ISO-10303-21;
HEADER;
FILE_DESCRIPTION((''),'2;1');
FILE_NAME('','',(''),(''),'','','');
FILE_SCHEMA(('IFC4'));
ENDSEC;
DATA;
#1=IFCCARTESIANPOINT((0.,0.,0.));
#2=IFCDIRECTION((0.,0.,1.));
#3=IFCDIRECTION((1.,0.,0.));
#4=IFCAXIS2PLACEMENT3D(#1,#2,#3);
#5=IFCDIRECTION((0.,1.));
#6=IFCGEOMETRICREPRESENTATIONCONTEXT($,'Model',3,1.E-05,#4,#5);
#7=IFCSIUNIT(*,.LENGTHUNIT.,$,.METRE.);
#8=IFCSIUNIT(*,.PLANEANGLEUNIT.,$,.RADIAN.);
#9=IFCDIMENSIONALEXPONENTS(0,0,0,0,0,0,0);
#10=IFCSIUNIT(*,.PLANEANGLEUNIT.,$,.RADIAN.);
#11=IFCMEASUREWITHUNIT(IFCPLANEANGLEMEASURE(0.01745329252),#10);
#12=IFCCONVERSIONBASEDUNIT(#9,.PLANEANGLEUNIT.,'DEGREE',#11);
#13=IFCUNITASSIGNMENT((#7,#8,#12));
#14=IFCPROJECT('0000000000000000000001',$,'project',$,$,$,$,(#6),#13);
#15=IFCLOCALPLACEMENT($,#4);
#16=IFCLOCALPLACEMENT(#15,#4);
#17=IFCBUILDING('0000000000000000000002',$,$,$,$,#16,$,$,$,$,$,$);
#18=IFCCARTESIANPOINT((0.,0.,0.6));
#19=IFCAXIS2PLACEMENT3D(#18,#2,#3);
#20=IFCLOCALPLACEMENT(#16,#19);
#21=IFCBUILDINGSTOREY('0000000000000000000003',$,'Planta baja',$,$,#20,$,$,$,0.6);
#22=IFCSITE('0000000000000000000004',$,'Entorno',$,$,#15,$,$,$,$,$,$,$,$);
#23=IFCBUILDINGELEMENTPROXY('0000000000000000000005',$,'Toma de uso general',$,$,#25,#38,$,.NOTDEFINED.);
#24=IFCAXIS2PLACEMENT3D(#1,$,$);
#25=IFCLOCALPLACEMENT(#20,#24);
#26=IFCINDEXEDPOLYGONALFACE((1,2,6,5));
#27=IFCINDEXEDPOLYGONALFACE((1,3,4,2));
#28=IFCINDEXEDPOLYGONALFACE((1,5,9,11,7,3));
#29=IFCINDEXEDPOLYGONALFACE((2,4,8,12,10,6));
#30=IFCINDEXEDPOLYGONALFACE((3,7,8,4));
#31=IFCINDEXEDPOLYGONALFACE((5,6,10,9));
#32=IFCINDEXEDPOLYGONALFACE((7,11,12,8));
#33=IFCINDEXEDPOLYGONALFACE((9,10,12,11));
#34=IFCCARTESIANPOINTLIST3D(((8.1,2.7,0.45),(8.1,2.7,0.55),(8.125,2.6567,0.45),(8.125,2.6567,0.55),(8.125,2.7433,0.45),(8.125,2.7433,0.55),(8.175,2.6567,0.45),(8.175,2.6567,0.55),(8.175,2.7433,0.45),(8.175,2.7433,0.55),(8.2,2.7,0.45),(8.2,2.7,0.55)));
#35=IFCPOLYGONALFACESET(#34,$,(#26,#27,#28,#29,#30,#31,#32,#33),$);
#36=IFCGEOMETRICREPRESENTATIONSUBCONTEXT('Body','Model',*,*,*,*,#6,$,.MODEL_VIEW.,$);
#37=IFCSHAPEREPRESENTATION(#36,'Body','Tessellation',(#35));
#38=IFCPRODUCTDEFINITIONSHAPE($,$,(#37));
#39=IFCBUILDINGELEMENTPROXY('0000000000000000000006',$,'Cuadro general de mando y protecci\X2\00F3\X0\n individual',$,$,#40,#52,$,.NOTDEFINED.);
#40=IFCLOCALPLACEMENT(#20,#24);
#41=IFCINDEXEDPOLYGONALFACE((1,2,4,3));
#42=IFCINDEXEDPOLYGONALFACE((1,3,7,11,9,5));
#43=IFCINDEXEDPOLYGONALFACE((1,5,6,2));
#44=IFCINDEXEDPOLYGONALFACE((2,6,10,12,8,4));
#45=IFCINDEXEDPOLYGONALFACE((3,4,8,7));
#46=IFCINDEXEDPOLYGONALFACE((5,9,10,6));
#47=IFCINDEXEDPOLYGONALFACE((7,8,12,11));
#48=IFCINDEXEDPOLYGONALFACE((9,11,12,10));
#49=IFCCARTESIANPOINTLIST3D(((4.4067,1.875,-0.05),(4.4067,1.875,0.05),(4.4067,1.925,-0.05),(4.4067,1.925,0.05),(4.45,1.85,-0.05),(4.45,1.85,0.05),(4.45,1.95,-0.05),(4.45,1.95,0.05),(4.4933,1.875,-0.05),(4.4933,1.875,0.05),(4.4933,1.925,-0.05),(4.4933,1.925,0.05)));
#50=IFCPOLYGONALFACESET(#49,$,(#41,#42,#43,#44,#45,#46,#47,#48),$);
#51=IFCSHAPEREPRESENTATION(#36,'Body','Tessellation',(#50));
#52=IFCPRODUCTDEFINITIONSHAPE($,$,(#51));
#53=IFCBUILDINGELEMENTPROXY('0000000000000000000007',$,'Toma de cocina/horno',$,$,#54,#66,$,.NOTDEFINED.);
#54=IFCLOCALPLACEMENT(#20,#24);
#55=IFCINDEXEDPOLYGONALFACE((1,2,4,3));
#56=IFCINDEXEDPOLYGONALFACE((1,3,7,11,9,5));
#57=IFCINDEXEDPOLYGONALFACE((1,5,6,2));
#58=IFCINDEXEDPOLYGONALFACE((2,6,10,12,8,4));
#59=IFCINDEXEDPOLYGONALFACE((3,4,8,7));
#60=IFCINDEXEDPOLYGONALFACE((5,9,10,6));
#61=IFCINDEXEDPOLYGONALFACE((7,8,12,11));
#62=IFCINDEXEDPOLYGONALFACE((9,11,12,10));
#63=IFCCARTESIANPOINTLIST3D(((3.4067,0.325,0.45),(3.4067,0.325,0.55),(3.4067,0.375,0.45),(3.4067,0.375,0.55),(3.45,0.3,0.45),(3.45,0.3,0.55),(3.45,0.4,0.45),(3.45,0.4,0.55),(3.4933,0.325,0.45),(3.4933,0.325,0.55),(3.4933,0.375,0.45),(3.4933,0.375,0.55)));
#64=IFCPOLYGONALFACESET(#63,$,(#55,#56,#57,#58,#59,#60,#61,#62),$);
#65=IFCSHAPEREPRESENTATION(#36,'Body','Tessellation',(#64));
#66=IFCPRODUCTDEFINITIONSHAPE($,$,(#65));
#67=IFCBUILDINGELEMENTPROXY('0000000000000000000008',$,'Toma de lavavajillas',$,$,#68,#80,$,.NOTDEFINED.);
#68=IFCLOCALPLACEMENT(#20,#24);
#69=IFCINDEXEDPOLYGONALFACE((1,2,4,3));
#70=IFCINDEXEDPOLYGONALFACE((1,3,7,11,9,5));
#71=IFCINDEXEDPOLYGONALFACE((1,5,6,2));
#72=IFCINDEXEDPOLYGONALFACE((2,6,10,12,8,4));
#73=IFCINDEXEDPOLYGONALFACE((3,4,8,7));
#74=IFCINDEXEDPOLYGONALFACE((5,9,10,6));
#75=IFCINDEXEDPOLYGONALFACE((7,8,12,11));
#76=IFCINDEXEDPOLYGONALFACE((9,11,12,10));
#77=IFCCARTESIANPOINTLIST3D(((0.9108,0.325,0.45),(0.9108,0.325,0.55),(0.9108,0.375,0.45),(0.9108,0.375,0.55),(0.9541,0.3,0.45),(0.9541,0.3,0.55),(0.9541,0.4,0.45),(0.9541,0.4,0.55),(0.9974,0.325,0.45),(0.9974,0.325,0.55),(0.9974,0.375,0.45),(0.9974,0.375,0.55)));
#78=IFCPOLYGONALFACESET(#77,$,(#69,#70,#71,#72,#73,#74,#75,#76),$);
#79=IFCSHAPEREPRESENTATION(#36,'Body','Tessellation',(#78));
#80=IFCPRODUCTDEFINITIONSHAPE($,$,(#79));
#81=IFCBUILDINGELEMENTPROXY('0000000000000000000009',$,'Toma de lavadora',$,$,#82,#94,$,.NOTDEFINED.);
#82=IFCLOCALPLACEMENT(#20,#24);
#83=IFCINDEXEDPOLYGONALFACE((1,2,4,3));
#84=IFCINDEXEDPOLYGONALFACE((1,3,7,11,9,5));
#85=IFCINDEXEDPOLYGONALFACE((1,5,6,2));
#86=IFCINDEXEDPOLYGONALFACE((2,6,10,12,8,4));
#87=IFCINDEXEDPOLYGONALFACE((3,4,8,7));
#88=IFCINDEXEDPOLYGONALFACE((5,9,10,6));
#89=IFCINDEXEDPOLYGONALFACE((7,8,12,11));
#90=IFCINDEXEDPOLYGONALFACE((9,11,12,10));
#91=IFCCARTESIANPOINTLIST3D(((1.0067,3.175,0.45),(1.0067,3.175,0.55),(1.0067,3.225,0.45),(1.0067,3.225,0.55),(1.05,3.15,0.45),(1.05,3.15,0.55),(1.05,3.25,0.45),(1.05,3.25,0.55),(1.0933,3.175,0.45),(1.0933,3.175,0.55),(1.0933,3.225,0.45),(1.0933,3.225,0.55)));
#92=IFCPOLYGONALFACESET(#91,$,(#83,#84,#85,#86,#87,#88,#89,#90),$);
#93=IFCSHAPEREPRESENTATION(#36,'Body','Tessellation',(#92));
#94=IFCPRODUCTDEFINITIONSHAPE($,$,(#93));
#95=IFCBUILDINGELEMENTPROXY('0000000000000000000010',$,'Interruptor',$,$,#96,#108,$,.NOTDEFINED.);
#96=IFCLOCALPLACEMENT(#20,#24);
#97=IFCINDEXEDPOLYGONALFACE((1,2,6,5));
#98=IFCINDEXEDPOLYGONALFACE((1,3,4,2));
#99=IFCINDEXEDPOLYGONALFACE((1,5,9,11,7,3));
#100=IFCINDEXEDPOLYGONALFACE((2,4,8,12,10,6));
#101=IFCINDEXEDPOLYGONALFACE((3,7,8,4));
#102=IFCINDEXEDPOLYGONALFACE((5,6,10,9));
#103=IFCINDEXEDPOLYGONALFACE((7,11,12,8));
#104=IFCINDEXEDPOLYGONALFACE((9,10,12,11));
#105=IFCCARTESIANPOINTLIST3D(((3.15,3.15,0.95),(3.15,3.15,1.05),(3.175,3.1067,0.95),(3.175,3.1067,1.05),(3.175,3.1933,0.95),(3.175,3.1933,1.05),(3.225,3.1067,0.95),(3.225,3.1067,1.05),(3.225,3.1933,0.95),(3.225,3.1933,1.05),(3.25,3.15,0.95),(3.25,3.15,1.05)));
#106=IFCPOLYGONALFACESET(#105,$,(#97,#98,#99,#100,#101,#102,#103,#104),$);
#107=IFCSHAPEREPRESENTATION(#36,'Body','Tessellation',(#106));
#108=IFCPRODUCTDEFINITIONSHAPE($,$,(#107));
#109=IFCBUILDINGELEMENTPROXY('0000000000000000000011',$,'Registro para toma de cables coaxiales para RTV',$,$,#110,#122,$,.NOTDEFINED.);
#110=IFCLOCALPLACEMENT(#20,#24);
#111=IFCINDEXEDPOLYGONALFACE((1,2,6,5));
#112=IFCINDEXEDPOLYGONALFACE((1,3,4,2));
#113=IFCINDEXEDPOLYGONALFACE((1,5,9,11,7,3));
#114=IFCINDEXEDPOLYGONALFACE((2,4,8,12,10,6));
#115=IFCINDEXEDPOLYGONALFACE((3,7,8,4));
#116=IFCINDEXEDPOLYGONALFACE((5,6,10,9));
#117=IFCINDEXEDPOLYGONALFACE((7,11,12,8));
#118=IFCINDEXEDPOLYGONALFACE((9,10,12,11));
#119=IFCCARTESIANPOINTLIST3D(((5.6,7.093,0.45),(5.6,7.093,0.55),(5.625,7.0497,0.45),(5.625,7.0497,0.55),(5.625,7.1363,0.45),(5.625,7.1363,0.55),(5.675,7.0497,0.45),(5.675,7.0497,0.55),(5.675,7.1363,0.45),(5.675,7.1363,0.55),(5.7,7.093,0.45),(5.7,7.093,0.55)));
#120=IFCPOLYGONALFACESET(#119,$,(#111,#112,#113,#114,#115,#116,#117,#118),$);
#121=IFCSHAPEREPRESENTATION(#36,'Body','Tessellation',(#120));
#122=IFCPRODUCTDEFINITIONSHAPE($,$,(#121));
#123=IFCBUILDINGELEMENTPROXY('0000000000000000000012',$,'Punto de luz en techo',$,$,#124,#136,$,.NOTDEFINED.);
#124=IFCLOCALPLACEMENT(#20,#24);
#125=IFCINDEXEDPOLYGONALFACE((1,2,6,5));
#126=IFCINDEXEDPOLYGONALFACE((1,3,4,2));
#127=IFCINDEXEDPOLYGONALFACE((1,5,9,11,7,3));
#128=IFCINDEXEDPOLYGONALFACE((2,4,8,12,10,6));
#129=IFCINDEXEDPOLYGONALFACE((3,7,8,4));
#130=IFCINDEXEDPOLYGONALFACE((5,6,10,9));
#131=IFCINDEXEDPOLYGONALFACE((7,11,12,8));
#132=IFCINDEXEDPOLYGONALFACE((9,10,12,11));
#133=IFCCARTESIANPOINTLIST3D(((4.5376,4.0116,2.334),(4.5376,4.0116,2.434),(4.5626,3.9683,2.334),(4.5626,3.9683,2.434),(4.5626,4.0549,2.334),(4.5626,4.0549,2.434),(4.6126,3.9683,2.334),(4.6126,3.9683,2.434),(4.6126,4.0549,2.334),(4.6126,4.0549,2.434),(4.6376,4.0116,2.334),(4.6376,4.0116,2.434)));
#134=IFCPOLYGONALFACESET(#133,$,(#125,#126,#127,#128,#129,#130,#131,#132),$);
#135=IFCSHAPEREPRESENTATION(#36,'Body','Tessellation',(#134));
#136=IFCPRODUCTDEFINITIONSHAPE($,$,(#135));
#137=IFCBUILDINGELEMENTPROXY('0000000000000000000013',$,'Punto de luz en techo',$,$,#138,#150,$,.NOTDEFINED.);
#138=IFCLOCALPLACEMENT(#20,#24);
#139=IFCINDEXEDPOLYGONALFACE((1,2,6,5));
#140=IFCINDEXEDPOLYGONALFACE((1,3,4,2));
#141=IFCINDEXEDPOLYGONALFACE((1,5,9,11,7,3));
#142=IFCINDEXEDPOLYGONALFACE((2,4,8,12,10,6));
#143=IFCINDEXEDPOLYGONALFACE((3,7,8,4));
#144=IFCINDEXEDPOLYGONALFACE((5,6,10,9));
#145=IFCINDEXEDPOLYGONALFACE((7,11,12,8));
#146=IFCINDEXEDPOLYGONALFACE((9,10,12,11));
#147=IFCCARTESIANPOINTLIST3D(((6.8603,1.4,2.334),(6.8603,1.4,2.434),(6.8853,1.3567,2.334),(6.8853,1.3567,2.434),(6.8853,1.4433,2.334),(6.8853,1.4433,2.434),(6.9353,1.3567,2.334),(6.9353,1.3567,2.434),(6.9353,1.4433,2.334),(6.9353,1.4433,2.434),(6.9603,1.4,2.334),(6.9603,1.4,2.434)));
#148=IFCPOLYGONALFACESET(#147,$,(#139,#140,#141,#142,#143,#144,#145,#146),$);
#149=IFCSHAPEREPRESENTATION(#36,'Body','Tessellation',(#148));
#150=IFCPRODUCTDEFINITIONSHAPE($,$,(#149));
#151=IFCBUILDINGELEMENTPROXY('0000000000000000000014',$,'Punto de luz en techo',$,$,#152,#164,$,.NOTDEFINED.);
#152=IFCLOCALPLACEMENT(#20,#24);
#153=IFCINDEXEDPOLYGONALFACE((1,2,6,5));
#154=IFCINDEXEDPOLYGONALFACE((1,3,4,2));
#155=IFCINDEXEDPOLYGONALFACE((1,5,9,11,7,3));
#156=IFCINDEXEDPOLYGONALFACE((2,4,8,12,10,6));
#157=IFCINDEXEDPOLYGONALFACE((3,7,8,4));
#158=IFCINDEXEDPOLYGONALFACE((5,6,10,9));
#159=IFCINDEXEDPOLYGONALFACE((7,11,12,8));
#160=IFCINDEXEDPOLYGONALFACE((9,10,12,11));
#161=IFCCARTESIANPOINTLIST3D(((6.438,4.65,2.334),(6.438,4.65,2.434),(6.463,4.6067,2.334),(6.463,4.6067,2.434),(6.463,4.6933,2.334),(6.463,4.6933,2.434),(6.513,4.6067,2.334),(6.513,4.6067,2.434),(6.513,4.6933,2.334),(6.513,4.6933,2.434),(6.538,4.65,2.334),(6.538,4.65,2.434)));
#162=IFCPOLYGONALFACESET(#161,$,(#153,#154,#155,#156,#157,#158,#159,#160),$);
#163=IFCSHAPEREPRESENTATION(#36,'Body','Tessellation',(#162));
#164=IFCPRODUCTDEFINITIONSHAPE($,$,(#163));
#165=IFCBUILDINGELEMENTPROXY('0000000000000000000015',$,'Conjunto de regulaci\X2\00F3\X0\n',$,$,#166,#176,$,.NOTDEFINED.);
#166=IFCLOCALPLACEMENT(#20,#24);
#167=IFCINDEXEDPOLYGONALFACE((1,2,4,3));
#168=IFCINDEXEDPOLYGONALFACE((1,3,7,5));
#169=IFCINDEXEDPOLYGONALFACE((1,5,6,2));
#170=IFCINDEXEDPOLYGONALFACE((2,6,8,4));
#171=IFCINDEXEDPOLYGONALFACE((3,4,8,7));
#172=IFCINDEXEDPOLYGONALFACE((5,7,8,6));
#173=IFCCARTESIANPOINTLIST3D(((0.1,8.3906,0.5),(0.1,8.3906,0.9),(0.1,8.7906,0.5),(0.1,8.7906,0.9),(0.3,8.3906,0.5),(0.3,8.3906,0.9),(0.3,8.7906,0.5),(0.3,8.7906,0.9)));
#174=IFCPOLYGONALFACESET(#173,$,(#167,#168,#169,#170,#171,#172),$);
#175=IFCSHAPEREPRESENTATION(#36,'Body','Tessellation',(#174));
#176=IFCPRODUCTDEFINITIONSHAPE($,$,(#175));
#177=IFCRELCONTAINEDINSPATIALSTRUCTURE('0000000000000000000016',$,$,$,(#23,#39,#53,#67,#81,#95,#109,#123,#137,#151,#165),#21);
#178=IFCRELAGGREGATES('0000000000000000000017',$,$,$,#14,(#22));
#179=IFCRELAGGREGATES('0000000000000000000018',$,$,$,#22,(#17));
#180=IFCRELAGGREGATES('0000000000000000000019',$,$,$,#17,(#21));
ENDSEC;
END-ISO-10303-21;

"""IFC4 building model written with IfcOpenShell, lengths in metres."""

from ifc_helpers import new_model, entity, si_unit, converted_unit, direction, frame, origin_with_axes, place, context, subcontext, project, spatial, polyline, outline, extrude, source, transform, mapped, element, save


model = new_model("IFC4")

# Units and contexts
model_context = context("Model", 3, precision=1e-05, world=origin_with_axes(), true_north=direction((0.0, 1.0)))
body_context = subcontext(model_context, "Body", "Model", "MODEL_VIEW")
ifc_project = project(units=[si_unit("LENGTHUNIT", "METRE"), si_unit("PLANEANGLEUNIT", "RADIAN"), converted_unit("PLANEANGLEUNIT", "DEGREE", entity("IfcPlaneAngleMeasure", 0.01745329252), si_unit("PLANEANGLEUNIT", "RADIAN"), dimensions=[0, 0, 0, 0, 0, 0, 0])], contexts=[model_context])

# Site, building, storey
site_placement = place(None, origin_with_axes())
site = spatial("IfcSite", under=ifc_project, at=site_placement, Name="Entorno")
building_placement = place(site_placement, origin_with_axes())
building = spatial("IfcBuilding", under=site, at=building_placement)
storey_placement = place(building_placement, frame((0.0, 0.0, 0.6), z_axis=(0.0, 0.0, 1.0), x_axis=(1.0, 0.0, 0.0)))
storey = spatial("IfcBuildingStorey", under=building, at=storey_placement, Name="Planta baja", Elevation=0.6)

# Building element proxies
shared_shape_1 = source(origin_with_axes(), body_context, "Body", "SolidModel", [
    extrude(outline(polyline([(0.05, 0.0), (0.025, 0.0433), (-0.025, 0.0433), (-0.05, 0.0), (-0.025, -0.0433), (0.025, -0.0433), (0.05, 0.0)])), frame((0.0, 0.0, -0.05), z_axis=(0.0, 0.0, 1.0), x_axis=(1.0, 0.0, 0.0)), (0.0, 0.0, 1.0), 0.1),
])
proxy_1_placement = place(storey_placement, frame((0.0, 0.0, -0.6), z_axis=(0.0, 0.0, 1.0), x_axis=(1.0, 0.0, 0.0)))
element("IfcBuildingElementProxy", 1, at=proxy_1_placement, inside=storey, Name="Toma de uso general", PredefinedType="NOTDEFINED", context=body_context, shape_type="Brep", body=[
    mapped(shared_shape_1, transform((8.15, 2.7, 1.1), x_axis=(-1.0, 0.0, 0.0), y_axis=(0.0, -1.0, 0.0), z_axis=(0.0, 0.0, 1.0))),
])
shared_shape_2 = source(origin_with_axes(), body_context, "Body", "SolidModel", [
    extrude(outline(polyline([(0.05, 0.0), (0.025, 0.0433), (-0.025, 0.0433), (-0.05, 0.0), (-0.025, -0.0433), (0.025, -0.0433), (0.05, 0.0)])), frame((0.0, 0.0, -0.05), z_axis=(0.0, 0.0, 1.0), x_axis=(1.0, 0.0, 0.0)), (0.0, 0.0, 1.0), 0.1),
])
proxy_2_placement = place(storey_placement, frame((0.0, 0.0, -0.6), z_axis=(0.0, 0.0, 1.0), x_axis=(1.0, 0.0, 0.0)))
element("IfcBuildingElementProxy", 2, at=proxy_2_placement, inside=storey, Name="Cuadro general de mando y protección individual", PredefinedType="NOTDEFINED", context=body_context, shape_type="Brep", body=[
    mapped(shared_shape_2, transform((4.45, 1.9, 0.6), x_axis=(0.0, -1.0, 0.0), y_axis=(1.0, 0.0, 0.0), z_axis=(0.0, 0.0, 1.0))),
])
shared_shape_3 = source(origin_with_axes(), body_context, "Body", "SolidModel", [
    extrude(outline(polyline([(0.05, 0.0), (0.025, 0.0433), (-0.025, 0.0433), (-0.05, 0.0), (-0.025, -0.0433), (0.025, -0.0433), (0.05, 0.0)])), frame((0.0, 0.0, -0.05), z_axis=(0.0, 0.0, 1.0), x_axis=(1.0, 0.0, 0.0)), (0.0, 0.0, 1.0), 0.1),
])
proxy_3_placement = place(storey_placement, frame((0.0, 0.0, -0.6), z_axis=(0.0, 0.0, 1.0), x_axis=(1.0, 0.0, 0.0)))
element("IfcBuildingElementProxy", 3, at=proxy_3_placement, inside=storey, Name="Toma de cocina/horno", PredefinedType="NOTDEFINED", context=body_context, shape_type="Brep", body=[
    mapped(shared_shape_3, transform((3.45, 0.35, 1.1), x_axis=(0.0, 1.0, 0.0), y_axis=(-1.0, 0.0, 0.0), z_axis=(0.0, 0.0, 1.0))),
])
shared_shape_4 = source(origin_with_axes(), body_context, "Body", "SolidModel", [
    extrude(outline(polyline([(0.05, 0.0), (0.025, 0.0433), (-0.025, 0.0433), (-0.05, 0.0), (-0.025, -0.0433), (0.025, -0.0433), (0.05, 0.0)])), frame((0.0, 0.0, -0.05), z_axis=(0.0, 0.0, 1.0), x_axis=(1.0, 0.0, 0.0)), (0.0, 0.0, 1.0), 0.1),
])
proxy_4_placement = place(storey_placement, frame((0.0, 0.0, -0.6), z_axis=(0.0, 0.0, 1.0), x_axis=(1.0, 0.0, 0.0)))
element("IfcBuildingElementProxy", 4, at=proxy_4_placement, inside=storey, Name="Toma de lavavajillas", PredefinedType="NOTDEFINED", context=body_context, shape_type="Brep", body=[
    mapped(shared_shape_4, transform((0.9541, 0.35, 1.1), x_axis=(0.0, 1.0, 0.0), y_axis=(-1.0, 0.0, 0.0), z_axis=(0.0, 0.0, 1.0))),
])
shared_shape_5 = source(origin_with_axes(), body_context, "Body", "SolidModel", [
    extrude(outline(polyline([(0.05, 0.0), (0.025, 0.0433), (-0.025, 0.0433), (-0.05, 0.0), (-0.025, -0.0433), (0.025, -0.0433), (0.05, 0.0)])), frame((0.0, 0.0, -0.05), z_axis=(0.0, 0.0, 1.0), x_axis=(1.0, 0.0, 0.0)), (0.0, 0.0, 1.0), 0.1),
])
proxy_5_placement = place(storey_placement, frame((0.0, 0.0, -0.6), z_axis=(0.0, 0.0, 1.0), x_axis=(1.0, 0.0, 0.0)))
element("IfcBuildingElementProxy", 5, at=proxy_5_placement, inside=storey, Name="Toma de lavadora", PredefinedType="NOTDEFINED", context=body_context, shape_type="Brep", body=[
    mapped(shared_shape_5, transform((1.05, 3.2, 1.1), x_axis=(0.0, -1.0, 0.0), y_axis=(1.0, 0.0, 0.0), z_axis=(0.0, 0.0, 1.0))),
])
shared_shape_6 = source(origin_with_axes(), body_context, "Body", "SolidModel", [
    extrude(outline(polyline([(0.05, 0.0), (0.025, 0.0433), (-0.025, 0.0433), (-0.05, 0.0), (-0.025, -0.0433), (0.025, -0.0433), (0.05, 0.0)])), frame((0.0, 0.0, -0.05), z_axis=(0.0, 0.0, 1.0), x_axis=(1.0, 0.0, 0.0)), (0.0, 0.0, 1.0), 0.1),
])
proxy_6_placement = place(storey_placement, frame((0.0, 0.0, -0.6), z_axis=(0.0, 0.0, 1.0), x_axis=(1.0, 0.0, 0.0)))
element("IfcBuildingElementProxy", 6, at=proxy_6_placement, inside=storey, Name="Interruptor", PredefinedType="NOTDEFINED", context=body_context, shape_type="Brep", body=[
    mapped(shared_shape_6, transform((3.2, 3.15, 1.6), x_axis=(1.0, 0.0, 0.0), y_axis=(0.0, 1.0, 0.0), z_axis=(0.0, 0.0, 1.0))),
])
shared_shape_7 = source(origin_with_axes(), body_context, "Body", "SolidModel", [
    extrude(outline(polyline([(0.05, 0.0), (0.025, 0.0433), (-0.025, 0.0433), (-0.05, 0.0), (-0.025, -0.0433), (0.025, -0.0433), (0.05, 0.0)])), frame((0.0, 0.0, -0.05), z_axis=(0.0, 0.0, 1.0), x_axis=(1.0, 0.0, 0.0)), (0.0, 0.0, 1.0), 0.1),
])
proxy_7_placement = place(storey_placement, frame((0.0, 0.0, -0.6), z_axis=(0.0, 0.0, 1.0), x_axis=(1.0, 0.0, 0.0)))
element("IfcBuildingElementProxy", 7, at=proxy_7_placement, inside=storey, Name="Registro para toma de cables coaxiales para RTV", PredefinedType="NOTDEFINED", context=body_context, shape_type="Brep", body=[
    mapped(shared_shape_7, transform((5.65, 7.093, 1.1), x_axis=(1.0, 0.0, 0.0), y_axis=(0.0, 1.0, 0.0), z_axis=(0.0, 0.0, 1.0))),
])
shared_shape_8 = source(origin_with_axes(), body_context, "Body", "SolidModel", [
    extrude(outline(polyline([(0.05, 0.0), (0.025, 0.0433), (-0.025, 0.0433), (-0.05, 0.0), (-0.025, -0.0433), (0.025, -0.0433), (0.05, 0.0)])), frame((0.0, 0.0, -0.05), z_axis=(0.0, 0.0, 1.0), x_axis=(1.0, 0.0, 0.0)), (0.0, 0.0, 1.0), 0.1),
])
proxy_8_placement = place(storey_placement, frame((0.0, 0.0, -0.6), z_axis=(0.0, 0.0, 1.0), x_axis=(1.0, 0.0, 0.0)))
element("IfcBuildingElementProxy", 8, at=proxy_8_placement, inside=storey, Name="Punto de luz en techo", PredefinedType="NOTDEFINED", context=body_context, shape_type="Brep", body=[
    mapped(shared_shape_8, transform((4.5876, 4.0116, 2.984), x_axis=(1.0, 0.0, 0.0), y_axis=(0.0, 1.0, 0.0), z_axis=(0.0, 0.0, 1.0))),
])
proxy_9_placement = place(storey_placement, frame((0.0, 0.0, -0.6), z_axis=(0.0, 0.0, 1.0), x_axis=(1.0, 0.0, 0.0)))
element("IfcBuildingElementProxy", 9, at=proxy_9_placement, inside=storey, Name="Punto de luz en techo", PredefinedType="NOTDEFINED", context=body_context, shape_type="Brep", body=[
    mapped(shared_shape_8, transform((6.9103, 1.4, 2.984), x_axis=(1.0, 0.0, 0.0), y_axis=(0.0, 1.0, 0.0), z_axis=(0.0, 0.0, 1.0))),
])
proxy_10_placement = place(storey_placement, frame((0.0, 0.0, -0.6), z_axis=(0.0, 0.0, 1.0), x_axis=(1.0, 0.0, 0.0)))
element("IfcBuildingElementProxy", 10, at=proxy_10_placement, inside=storey, Name="Punto de luz en techo", PredefinedType="NOTDEFINED", context=body_context, shape_type="Brep", body=[
    mapped(shared_shape_8, transform((6.488, 4.65, 2.984), x_axis=(1.0, 0.0, 0.0), y_axis=(0.0, 1.0, 0.0), z_axis=(0.0, 0.0, 1.0))),
])
proxy_11_placement = place(storey_placement, frame((0.0, 0.0, -0.6), z_axis=(0.0, 0.0, 1.0), x_axis=(1.0, 0.0, 0.0)))
element("IfcBuildingElementProxy", 11, at=proxy_11_placement, inside=storey, Name="Conjunto de regulación", PredefinedType="NOTDEFINED", context=body_context, shape_type="Brep", body=[
    extrude(outline(polyline([(-0.2, -0.1), (0.2, -0.1), (0.2, 0.1), (-0.2, 0.1), (-0.2, -0.1)])), frame((0.2, 8.5906, 1.1), z_axis=(0.0, 0.0, 1.0), x_axis=(0.0, -1.0, 0.0)), (0.0, 0.0, 1.0), 0.4),
])

save(model, "model.ifc")
